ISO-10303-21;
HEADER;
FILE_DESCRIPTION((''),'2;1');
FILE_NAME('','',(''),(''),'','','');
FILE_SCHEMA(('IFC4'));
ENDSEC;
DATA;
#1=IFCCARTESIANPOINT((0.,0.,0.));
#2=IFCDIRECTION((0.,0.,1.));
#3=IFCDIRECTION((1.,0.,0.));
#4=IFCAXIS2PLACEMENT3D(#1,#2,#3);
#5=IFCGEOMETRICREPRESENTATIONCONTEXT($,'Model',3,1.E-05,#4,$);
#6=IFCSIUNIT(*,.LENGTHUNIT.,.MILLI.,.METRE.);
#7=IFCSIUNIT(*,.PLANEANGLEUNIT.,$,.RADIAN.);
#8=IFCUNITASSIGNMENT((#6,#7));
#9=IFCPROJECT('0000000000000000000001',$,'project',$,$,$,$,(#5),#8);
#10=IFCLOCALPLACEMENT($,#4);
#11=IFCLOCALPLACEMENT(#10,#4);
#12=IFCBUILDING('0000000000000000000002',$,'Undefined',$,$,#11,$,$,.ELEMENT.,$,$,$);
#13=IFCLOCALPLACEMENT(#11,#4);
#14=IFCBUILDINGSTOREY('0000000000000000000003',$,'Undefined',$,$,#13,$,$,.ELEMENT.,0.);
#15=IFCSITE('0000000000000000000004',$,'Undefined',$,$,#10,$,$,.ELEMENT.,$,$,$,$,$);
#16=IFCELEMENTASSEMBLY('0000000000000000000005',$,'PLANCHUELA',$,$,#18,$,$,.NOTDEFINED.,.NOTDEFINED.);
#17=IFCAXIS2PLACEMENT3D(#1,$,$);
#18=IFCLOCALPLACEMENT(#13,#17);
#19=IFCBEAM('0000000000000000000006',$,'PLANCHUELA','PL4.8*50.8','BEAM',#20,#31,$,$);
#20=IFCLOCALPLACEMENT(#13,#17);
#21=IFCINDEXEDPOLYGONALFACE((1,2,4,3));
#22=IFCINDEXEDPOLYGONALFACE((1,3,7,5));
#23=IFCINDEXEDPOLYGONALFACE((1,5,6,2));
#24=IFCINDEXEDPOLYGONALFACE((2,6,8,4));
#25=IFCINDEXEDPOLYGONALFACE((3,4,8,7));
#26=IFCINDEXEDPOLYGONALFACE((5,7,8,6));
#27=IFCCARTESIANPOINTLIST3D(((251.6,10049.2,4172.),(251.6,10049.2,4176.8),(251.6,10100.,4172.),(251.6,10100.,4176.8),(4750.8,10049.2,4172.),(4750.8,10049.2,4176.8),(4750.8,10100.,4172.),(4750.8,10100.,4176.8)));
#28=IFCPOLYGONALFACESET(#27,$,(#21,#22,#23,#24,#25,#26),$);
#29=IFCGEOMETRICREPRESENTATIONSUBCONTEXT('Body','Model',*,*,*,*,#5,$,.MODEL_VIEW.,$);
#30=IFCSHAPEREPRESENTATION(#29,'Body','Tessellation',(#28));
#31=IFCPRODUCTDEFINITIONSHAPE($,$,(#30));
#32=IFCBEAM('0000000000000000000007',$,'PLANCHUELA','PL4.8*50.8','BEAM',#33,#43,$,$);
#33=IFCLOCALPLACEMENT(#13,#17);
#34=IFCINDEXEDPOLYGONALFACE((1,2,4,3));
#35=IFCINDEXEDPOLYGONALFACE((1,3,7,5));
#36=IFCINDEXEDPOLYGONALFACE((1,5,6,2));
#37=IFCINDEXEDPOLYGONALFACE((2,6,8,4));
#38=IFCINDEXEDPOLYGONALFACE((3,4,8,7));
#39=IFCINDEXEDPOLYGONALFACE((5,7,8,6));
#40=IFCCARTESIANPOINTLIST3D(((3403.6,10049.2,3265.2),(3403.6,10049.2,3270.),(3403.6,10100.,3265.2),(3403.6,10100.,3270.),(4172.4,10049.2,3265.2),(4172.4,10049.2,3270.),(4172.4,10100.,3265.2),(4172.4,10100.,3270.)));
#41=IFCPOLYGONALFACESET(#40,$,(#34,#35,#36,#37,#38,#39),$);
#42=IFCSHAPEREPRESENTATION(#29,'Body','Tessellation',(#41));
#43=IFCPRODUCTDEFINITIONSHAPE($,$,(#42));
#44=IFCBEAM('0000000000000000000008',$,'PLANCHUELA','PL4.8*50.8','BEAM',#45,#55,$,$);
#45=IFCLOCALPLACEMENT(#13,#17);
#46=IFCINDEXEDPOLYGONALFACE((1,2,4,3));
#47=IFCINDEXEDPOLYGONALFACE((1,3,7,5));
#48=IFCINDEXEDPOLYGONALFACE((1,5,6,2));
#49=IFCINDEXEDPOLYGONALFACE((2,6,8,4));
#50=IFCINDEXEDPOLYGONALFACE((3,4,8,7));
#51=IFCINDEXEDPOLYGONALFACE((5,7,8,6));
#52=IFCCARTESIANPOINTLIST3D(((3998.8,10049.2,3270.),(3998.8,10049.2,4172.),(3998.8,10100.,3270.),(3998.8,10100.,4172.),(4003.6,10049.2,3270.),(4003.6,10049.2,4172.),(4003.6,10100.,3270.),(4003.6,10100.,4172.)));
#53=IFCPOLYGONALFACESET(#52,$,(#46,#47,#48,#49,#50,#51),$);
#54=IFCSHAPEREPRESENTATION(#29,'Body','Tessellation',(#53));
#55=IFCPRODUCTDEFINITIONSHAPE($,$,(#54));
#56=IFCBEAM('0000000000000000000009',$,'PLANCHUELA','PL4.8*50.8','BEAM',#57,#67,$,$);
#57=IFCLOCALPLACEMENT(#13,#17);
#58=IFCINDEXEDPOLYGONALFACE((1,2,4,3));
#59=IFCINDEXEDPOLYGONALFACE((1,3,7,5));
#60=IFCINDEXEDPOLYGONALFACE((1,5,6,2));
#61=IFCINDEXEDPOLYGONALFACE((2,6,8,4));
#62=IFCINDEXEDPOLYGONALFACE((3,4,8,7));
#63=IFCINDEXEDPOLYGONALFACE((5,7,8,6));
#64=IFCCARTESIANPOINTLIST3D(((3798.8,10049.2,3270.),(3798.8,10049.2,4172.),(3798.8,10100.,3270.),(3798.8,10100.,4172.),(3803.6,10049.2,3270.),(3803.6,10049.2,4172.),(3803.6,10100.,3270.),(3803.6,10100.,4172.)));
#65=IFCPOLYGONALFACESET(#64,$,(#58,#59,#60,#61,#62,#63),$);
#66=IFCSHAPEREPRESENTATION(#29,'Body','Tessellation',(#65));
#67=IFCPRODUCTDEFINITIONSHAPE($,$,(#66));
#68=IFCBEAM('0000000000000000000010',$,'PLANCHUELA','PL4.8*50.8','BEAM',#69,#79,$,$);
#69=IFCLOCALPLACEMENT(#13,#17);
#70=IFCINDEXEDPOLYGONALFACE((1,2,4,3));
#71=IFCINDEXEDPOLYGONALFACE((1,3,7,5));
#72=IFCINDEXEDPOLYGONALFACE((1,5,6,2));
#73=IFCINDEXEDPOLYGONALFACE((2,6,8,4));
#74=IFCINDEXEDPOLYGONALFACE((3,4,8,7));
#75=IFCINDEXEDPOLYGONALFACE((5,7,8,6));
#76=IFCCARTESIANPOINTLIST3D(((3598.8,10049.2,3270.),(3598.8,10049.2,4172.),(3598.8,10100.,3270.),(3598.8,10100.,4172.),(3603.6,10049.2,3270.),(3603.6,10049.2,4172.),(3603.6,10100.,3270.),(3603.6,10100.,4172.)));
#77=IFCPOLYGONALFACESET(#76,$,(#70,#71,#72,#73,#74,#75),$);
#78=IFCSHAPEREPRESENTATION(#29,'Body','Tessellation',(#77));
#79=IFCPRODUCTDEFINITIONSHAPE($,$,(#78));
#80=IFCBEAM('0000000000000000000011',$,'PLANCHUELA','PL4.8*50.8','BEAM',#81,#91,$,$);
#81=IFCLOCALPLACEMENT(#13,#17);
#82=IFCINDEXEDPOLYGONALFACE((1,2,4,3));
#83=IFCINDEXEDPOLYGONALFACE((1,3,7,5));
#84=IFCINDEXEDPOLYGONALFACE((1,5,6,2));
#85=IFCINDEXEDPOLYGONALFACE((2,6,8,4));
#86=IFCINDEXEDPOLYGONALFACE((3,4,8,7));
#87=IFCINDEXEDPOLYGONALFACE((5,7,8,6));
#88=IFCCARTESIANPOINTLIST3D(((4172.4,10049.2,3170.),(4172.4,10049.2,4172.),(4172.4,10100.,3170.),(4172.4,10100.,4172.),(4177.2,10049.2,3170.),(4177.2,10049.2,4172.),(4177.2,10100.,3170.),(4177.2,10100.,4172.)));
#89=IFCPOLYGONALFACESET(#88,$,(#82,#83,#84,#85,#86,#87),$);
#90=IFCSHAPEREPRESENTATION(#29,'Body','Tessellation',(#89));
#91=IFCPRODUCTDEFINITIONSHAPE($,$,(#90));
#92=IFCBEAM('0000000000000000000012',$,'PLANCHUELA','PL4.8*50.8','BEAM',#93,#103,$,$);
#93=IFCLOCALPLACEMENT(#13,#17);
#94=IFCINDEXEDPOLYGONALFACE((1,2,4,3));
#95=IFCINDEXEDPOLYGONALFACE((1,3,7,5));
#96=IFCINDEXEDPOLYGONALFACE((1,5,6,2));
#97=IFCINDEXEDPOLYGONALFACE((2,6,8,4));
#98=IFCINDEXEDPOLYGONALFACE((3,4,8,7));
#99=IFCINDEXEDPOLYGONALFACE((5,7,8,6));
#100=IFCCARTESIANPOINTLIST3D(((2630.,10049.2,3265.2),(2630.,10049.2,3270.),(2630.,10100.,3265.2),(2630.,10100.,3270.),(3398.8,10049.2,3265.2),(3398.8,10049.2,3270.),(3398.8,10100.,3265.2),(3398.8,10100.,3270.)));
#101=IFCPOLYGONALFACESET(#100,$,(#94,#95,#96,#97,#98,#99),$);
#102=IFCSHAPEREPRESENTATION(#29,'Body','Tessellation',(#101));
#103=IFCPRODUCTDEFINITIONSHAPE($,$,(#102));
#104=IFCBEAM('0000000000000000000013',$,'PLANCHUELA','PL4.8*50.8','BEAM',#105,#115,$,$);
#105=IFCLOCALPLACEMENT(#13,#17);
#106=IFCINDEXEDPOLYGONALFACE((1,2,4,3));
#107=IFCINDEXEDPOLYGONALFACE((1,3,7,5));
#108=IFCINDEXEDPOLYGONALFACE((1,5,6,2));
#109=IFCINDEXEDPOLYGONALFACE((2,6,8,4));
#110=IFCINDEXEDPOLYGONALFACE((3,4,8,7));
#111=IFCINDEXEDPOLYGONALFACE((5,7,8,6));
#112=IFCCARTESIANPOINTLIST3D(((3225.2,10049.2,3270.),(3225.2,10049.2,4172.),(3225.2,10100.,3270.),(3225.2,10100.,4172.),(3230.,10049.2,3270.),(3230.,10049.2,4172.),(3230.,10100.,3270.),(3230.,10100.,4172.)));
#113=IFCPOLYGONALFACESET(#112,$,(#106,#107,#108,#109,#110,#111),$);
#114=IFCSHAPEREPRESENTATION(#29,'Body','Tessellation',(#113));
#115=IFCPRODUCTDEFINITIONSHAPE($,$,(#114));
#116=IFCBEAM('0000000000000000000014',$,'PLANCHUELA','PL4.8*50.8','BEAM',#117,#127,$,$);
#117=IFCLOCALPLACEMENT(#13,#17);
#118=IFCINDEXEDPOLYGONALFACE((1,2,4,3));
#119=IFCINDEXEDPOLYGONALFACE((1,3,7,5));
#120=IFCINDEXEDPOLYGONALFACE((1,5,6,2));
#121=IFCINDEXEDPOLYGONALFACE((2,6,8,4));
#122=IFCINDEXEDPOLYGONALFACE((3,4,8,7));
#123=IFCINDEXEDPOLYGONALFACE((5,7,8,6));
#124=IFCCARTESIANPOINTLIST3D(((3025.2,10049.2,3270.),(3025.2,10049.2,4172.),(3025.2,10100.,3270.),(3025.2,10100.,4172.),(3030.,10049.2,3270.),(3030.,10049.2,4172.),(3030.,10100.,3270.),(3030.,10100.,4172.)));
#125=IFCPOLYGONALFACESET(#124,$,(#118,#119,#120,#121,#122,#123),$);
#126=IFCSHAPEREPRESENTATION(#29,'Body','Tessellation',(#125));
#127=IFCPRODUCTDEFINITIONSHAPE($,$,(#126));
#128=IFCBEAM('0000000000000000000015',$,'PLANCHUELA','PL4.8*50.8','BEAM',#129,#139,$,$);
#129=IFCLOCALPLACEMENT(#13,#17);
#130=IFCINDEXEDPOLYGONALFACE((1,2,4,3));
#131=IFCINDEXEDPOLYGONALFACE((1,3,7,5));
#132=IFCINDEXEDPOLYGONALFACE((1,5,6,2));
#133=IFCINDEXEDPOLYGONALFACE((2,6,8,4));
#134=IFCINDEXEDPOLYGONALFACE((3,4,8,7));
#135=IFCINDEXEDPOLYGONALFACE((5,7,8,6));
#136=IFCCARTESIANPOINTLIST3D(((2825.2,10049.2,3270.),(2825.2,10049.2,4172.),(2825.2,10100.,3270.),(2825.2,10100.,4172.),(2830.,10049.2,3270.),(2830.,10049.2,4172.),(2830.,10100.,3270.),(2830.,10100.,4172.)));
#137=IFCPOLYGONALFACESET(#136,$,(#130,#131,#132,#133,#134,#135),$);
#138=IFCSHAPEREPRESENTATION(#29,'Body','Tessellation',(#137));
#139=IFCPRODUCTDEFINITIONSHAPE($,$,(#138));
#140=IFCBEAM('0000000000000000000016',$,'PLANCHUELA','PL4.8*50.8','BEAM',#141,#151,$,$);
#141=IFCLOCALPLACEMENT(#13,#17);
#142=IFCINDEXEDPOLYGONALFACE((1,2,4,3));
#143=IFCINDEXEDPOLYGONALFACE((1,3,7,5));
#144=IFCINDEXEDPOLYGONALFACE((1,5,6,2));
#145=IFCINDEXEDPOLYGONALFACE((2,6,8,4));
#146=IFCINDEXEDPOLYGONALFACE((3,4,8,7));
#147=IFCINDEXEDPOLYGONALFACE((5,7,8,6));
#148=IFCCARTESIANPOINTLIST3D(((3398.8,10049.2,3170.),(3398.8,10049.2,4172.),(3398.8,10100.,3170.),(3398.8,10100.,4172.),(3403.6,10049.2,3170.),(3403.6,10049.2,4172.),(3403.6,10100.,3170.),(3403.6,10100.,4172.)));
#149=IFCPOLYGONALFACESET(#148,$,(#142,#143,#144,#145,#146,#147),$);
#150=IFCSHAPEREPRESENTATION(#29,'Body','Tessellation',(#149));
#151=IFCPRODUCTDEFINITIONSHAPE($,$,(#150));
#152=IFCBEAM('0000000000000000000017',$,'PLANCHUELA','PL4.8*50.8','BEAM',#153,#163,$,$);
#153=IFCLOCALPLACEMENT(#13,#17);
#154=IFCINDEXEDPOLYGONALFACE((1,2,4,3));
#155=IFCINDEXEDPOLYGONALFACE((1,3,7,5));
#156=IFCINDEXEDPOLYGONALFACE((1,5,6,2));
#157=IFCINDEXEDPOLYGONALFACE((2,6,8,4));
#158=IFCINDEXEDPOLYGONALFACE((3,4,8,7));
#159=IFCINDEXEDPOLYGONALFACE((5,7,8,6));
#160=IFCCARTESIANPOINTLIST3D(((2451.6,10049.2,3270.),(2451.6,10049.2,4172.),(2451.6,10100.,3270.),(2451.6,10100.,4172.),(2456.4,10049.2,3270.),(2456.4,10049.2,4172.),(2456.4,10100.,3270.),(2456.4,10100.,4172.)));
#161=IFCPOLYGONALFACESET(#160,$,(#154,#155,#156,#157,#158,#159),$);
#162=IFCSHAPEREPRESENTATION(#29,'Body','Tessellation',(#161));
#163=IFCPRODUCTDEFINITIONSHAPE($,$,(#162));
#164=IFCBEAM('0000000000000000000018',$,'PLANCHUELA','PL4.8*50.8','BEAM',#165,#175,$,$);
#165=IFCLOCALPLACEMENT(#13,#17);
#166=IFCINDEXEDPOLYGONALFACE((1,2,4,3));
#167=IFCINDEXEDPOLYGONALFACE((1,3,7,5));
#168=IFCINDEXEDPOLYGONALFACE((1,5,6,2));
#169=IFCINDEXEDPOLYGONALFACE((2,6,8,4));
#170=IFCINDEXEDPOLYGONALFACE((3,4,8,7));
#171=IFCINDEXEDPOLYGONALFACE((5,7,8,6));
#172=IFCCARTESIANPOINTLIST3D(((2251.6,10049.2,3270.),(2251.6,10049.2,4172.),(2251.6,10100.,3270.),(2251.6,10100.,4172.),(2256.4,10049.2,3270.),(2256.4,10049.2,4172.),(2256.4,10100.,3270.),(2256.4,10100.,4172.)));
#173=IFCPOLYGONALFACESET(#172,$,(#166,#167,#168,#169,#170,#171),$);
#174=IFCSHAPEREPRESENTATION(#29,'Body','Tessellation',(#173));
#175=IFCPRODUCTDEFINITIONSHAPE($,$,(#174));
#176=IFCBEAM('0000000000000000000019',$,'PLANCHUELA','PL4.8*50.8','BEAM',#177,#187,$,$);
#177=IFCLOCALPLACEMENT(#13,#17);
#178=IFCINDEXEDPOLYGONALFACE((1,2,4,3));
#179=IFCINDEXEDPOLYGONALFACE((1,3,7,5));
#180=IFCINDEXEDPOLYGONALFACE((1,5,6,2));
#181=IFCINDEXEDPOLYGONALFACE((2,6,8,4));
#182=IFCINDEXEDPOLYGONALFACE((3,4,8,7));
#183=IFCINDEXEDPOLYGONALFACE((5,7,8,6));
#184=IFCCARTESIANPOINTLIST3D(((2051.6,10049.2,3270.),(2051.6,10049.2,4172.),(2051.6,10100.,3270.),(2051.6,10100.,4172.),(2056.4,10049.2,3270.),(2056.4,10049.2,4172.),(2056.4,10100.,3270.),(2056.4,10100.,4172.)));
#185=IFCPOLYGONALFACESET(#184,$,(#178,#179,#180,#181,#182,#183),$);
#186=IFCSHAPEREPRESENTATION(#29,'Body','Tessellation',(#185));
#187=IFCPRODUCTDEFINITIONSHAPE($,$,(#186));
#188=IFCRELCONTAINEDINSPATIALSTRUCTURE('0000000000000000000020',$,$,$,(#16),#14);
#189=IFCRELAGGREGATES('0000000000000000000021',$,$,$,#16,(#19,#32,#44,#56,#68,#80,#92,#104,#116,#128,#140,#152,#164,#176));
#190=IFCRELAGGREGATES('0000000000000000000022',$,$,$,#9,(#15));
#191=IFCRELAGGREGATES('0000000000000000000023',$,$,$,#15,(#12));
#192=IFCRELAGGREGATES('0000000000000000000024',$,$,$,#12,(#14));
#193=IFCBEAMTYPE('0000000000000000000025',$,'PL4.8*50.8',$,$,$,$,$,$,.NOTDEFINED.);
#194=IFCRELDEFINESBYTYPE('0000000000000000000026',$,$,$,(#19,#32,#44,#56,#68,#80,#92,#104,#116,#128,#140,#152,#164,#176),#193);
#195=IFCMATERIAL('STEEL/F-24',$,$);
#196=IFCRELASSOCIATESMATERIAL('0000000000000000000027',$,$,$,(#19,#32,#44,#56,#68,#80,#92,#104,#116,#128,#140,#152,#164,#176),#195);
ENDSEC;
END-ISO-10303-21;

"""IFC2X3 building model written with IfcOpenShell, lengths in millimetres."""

from ifc_helpers import new_model, si_unit, frame, origin_with_axes, origin_2d_with_axis, place, context, subcontext, project, spatial, rectangle, extrude, material, type_object, element, aggregate, save


model = new_model("IFC2X3")

# Units and contexts
model_context = context("Model", 3, precision=1e-05, world=origin_with_axes())
body_context = subcontext(model_context, "Body", "Model", "MODEL_VIEW")
ifc_project = project(units=[si_unit("LENGTHUNIT", "METRE", prefix="MILLI"), si_unit("PLANEANGLEUNIT", "RADIAN")], contexts=[model_context])

# Site, building, storey
site_placement = place(None, origin_with_axes())
site = spatial("IfcSite", under=ifc_project, at=site_placement, Name="Undefined", CompositionType="ELEMENT")
building_placement = place(site_placement, origin_with_axes())
building = spatial("IfcBuilding", under=site, at=building_placement, Name="Undefined", CompositionType="ELEMENT")
storey_placement = place(building_placement, origin_with_axes())
storey = spatial("IfcBuildingStorey", under=building, at=storey_placement, Name="Undefined", CompositionType="ELEMENT", Elevation=0.0)

# Element assembly, beams
assembly_1_placement = place(storey_placement, origin_with_axes())
assembly_1 = element("IfcElementAssembly", 1, at=assembly_1_placement, inside=storey, Name="PLANCHUELA", AssemblyPlace="NOTDEFINED", PredefinedType="NOTDEFINED")
ifc_material_1 = material(Name="STEEL/F-24")
beam_type = type_object("IfcBeamType", Name="PL4.8*50.8", PredefinedType="NOTDEFINED")
beam_1_placement = place(assembly_1_placement, frame((251.6, 10074.6, 4174.4), z_axis=(0.0, -1.0, 0.0), x_axis=(1.0, 0.0, 0.0)))
beam_1 = element("IfcBeam", 2, at=beam_1_placement, type_object=beam_type, material=ifc_material_1, Name="PLANCHUELA", Description="PL4.8*50.8", ObjectType="BEAM", context=body_context, shape_type="SweptSolid", body=[
    extrude(rectangle(XDim=4.8, YDim=50.8, at=origin_2d_with_axis()), frame((4499.2, 0.0, 0.0), z_axis=(-1.0, 0.0, 0.0), x_axis=(0.0, -1.0, 0.0)), (0.0, 0.0, 1.0), 4499.2),
])
beam_2_placement = place(assembly_1_placement, frame((3403.6, 10074.6, 3267.6), z_axis=(0.0, -1.0, 0.0), x_axis=(1.0, 0.0, 0.0)))
beam_2 = element("IfcBeam", 3, at=beam_2_placement, type_object=beam_type, material=ifc_material_1, Name="PLANCHUELA", Description="PL4.8*50.8", ObjectType="BEAM", context=body_context, shape_type="SweptSolid", body=[
    extrude(rectangle(XDim=4.8, YDim=50.8, at=origin_2d_with_axis()), frame((768.8, 0.0, 0.0), z_axis=(-1.0, 0.0, 0.0), x_axis=(0.0, -1.0, 0.0)), (0.0, 0.0, 1.0), 768.8),
])
beam_3_placement = place(assembly_1_placement, frame((4001.2, 10074.6, 4172.0), z_axis=(0.0, -1.0, 0.0), x_axis=(0.0, 0.0, -1.0)))
beam_3 = element("IfcBeam", 4, at=beam_3_placement, type_object=beam_type, material=ifc_material_1, Name="PLANCHUELA", Description="PL4.8*50.8", ObjectType="BEAM", context=body_context, shape_type="SweptSolid", body=[
    extrude(rectangle(XDim=4.8, YDim=50.8, at=origin_2d_with_axis()), frame((902.0, 0.0, 0.0), z_axis=(-1.0, 0.0, 0.0), x_axis=(0.0, -1.0, 0.0)), (0.0, 0.0, 1.0), 902.0),
])
beam_4_placement = place(assembly_1_placement, frame((3801.2, 10074.6, 4172.0), z_axis=(0.0, -1.0, 0.0), x_axis=(0.0, 0.0, -1.0)))
beam_4 = element("IfcBeam", 5, at=beam_4_placement, type_object=beam_type, material=ifc_material_1, Name="PLANCHUELA", Description="PL4.8*50.8", ObjectType="BEAM", context=body_context, shape_type="SweptSolid", body=[
    extrude(rectangle(XDim=4.8, YDim=50.8, at=origin_2d_with_axis()), frame((902.0, 0.0, 0.0), z_axis=(-1.0, 0.0, 0.0), x_axis=(0.0, -1.0, 0.0)), (0.0, 0.0, 1.0), 902.0),
])
beam_5_placement = place(assembly_1_placement, frame((3601.2, 10074.6, 4172.0), z_axis=(0.0, -1.0, 0.0), x_axis=(0.0, 0.0, -1.0)))
beam_5 = element("IfcBeam", 6, at=beam_5_placement, type_object=beam_type, material=ifc_material_1, Name="PLANCHUELA", Description="PL4.8*50.8", ObjectType="BEAM", context=body_context, shape_type="SweptSolid", body=[
    extrude(rectangle(XDim=4.8, YDim=50.8, at=origin_2d_with_axis()), frame((902.0, 0.0, 0.0), z_axis=(-1.0, 0.0, 0.0), x_axis=(0.0, -1.0, 0.0)), (0.0, 0.0, 1.0), 902.0),
])
beam_6_placement = place(assembly_1_placement, frame((4174.8, 10074.6, 4172.0), z_axis=(0.0, -1.0, 0.0), x_axis=(0.0, 0.0, -1.0)))
beam_6 = element("IfcBeam", 7, at=beam_6_placement, type_object=beam_type, material=ifc_material_1, Name="PLANCHUELA", Description="PL4.8*50.8", ObjectType="BEAM", context=body_context, shape_type="SweptSolid", body=[
    extrude(rectangle(XDim=4.8, YDim=50.8, at=origin_2d_with_axis()), frame((1002.0, 0.0, 0.0), z_axis=(-1.0, 0.0, 0.0), x_axis=(0.0, -1.0, 0.0)), (0.0, 0.0, 1.0), 1002.0),
])
beam_7_placement = place(assembly_1_placement, frame((2630.0, 10074.6, 3267.6), z_axis=(0.0, -1.0, 0.0), x_axis=(1.0, 0.0, 0.0)))
beam_7 = element("IfcBeam", 8, at=beam_7_placement, type_object=beam_type, material=ifc_material_1, Name="PLANCHUELA", Description="PL4.8*50.8", ObjectType="BEAM", context=body_context, shape_type="SweptSolid", body=[
    extrude(rectangle(XDim=4.8, YDim=50.8, at=origin_2d_with_axis()), frame((768.8, 0.0, 0.0), z_axis=(-1.0, 0.0, 0.0), x_axis=(0.0, -1.0, 0.0)), (0.0, 0.0, 1.0), 768.8),
])
beam_8_placement = place(assembly_1_placement, frame((3227.6, 10074.6, 4172.0), z_axis=(0.0, -1.0, 0.0), x_axis=(0.0, 0.0, -1.0)))
beam_8 = element("IfcBeam", 9, at=beam_8_placement, type_object=beam_type, material=ifc_material_1, Name="PLANCHUELA", Description="PL4.8*50.8", ObjectType="BEAM", context=body_context, shape_type="SweptSolid", body=[
    extrude(rectangle(XDim=4.8, YDim=50.8, at=origin_2d_with_axis()), frame((902.0, 0.0, 0.0), z_axis=(-1.0, 0.0, 0.0), x_axis=(0.0, -1.0, 0.0)), (0.0, 0.0, 1.0), 902.0),
])
beam_9_placement = place(assembly_1_placement, frame((3027.6, 10074.6, 4172.0), z_axis=(0.0, -1.0, 0.0), x_axis=(0.0, 0.0, -1.0)))
beam_9 = element("IfcBeam", 10, at=beam_9_placement, type_object=beam_type, material=ifc_material_1, Name="PLANCHUELA", Description="PL4.8*50.8", ObjectType="BEAM", context=body_context, shape_type="SweptSolid", body=[
    extrude(rectangle(XDim=4.8, YDim=50.8, at=origin_2d_with_axis()), frame((902.0, 0.0, 0.0), z_axis=(-1.0, 0.0, 0.0), x_axis=(0.0, -1.0, 0.0)), (0.0, 0.0, 1.0), 902.0),
])
beam_10_placement = place(assembly_1_placement, frame((2827.6, 10074.6, 4172.0), z_axis=(0.0, -1.0, 0.0), x_axis=(0.0, 0.0, -1.0)))
beam_10 = element("IfcBeam", 11, at=beam_10_placement, type_object=beam_type, material=ifc_material_1, Name="PLANCHUELA", Description="PL4.8*50.8", ObjectType="BEAM", context=body_context, shape_type="SweptSolid", body=[
    extrude(rectangle(XDim=4.8, YDim=50.8, at=origin_2d_with_axis()), frame((902.0, 0.0, 0.0), z_axis=(-1.0, 0.0, 0.0), x_axis=(0.0, -1.0, 0.0)), (0.0, 0.0, 1.0), 902.0),
])
beam_11_placement = place(assembly_1_placement, frame((3401.2, 10074.6, 4172.0), z_axis=(0.0, -1.0, 0.0), x_axis=(0.0, 0.0, -1.0)))
beam_11 = element("IfcBeam", 12, at=beam_11_placement, type_object=beam_type, material=ifc_material_1, Name="PLANCHUELA", Description="PL4.8*50.8", ObjectType="BEAM", context=body_context, shape_type="SweptSolid", body=[
    extrude(rectangle(XDim=4.8, YDim=50.8, at=origin_2d_with_axis()), frame((1002.0, 0.0, 0.0), z_axis=(-1.0, 0.0, 0.0), x_axis=(0.0, -1.0, 0.0)), (0.0, 0.0, 1.0), 1002.0),
])
beam_12_placement = place(assembly_1_placement, frame((2454.0, 10074.6, 4172.0), z_axis=(0.0, -1.0, 0.0), x_axis=(0.0, 0.0, -1.0)))
beam_12 = element("IfcBeam", 13, at=beam_12_placement, type_object=beam_type, material=ifc_material_1, Name="PLANCHUELA", Description="PL4.8*50.8", ObjectType="BEAM", context=body_context, shape_type="SweptSolid", body=[
    extrude(rectangle(XDim=4.8, YDim=50.8, at=origin_2d_with_axis()), frame((902.0, 0.0, 0.0), z_axis=(-1.0, 0.0, 0.0), x_axis=(0.0, -1.0, 0.0)), (0.0, 0.0, 1.0), 902.0),
])
beam_13_placement = place(assembly_1_placement, frame((2254.0, 10074.6, 4172.0), z_axis=(0.0, -1.0, 0.0), x_axis=(0.0, 0.0, -1.0)))
beam_13 = element("IfcBeam", 14, at=beam_13_placement, type_object=beam_type, material=ifc_material_1, Name="PLANCHUELA", Description="PL4.8*50.8", ObjectType="BEAM", context=body_context, shape_type="SweptSolid", body=[
    extrude(rectangle(XDim=4.8, YDim=50.8, at=origin_2d_with_axis()), frame((902.0, 0.0, 0.0), z_axis=(-1.0, 0.0, 0.0), x_axis=(0.0, -1.0, 0.0)), (0.0, 0.0, 1.0), 902.0),
])
beam_14_placement = place(assembly_1_placement, frame((2054.0, 10074.6, 4172.0), z_axis=(0.0, -1.0, 0.0), x_axis=(0.0, 0.0, -1.0)))
beam_14 = element("IfcBeam", 15, at=beam_14_placement, type_object=beam_type, material=ifc_material_1, Name="PLANCHUELA", Description="PL4.8*50.8", ObjectType="BEAM", context=body_context, shape_type="SweptSolid", body=[
    extrude(rectangle(XDim=4.8, YDim=50.8, at=origin_2d_with_axis()), frame((902.0, 0.0, 0.0), z_axis=(-1.0, 0.0, 0.0), x_axis=(0.0, -1.0, 0.0)), (0.0, 0.0, 1.0), 902.0),
])
aggregate(assembly_1, [beam_1, beam_2, beam_3, beam_4, beam_5, beam_6, beam_7, beam_8, beam_9, beam_10, beam_11, beam_12, beam_13, beam_14])

save(model, "model.ifc")
